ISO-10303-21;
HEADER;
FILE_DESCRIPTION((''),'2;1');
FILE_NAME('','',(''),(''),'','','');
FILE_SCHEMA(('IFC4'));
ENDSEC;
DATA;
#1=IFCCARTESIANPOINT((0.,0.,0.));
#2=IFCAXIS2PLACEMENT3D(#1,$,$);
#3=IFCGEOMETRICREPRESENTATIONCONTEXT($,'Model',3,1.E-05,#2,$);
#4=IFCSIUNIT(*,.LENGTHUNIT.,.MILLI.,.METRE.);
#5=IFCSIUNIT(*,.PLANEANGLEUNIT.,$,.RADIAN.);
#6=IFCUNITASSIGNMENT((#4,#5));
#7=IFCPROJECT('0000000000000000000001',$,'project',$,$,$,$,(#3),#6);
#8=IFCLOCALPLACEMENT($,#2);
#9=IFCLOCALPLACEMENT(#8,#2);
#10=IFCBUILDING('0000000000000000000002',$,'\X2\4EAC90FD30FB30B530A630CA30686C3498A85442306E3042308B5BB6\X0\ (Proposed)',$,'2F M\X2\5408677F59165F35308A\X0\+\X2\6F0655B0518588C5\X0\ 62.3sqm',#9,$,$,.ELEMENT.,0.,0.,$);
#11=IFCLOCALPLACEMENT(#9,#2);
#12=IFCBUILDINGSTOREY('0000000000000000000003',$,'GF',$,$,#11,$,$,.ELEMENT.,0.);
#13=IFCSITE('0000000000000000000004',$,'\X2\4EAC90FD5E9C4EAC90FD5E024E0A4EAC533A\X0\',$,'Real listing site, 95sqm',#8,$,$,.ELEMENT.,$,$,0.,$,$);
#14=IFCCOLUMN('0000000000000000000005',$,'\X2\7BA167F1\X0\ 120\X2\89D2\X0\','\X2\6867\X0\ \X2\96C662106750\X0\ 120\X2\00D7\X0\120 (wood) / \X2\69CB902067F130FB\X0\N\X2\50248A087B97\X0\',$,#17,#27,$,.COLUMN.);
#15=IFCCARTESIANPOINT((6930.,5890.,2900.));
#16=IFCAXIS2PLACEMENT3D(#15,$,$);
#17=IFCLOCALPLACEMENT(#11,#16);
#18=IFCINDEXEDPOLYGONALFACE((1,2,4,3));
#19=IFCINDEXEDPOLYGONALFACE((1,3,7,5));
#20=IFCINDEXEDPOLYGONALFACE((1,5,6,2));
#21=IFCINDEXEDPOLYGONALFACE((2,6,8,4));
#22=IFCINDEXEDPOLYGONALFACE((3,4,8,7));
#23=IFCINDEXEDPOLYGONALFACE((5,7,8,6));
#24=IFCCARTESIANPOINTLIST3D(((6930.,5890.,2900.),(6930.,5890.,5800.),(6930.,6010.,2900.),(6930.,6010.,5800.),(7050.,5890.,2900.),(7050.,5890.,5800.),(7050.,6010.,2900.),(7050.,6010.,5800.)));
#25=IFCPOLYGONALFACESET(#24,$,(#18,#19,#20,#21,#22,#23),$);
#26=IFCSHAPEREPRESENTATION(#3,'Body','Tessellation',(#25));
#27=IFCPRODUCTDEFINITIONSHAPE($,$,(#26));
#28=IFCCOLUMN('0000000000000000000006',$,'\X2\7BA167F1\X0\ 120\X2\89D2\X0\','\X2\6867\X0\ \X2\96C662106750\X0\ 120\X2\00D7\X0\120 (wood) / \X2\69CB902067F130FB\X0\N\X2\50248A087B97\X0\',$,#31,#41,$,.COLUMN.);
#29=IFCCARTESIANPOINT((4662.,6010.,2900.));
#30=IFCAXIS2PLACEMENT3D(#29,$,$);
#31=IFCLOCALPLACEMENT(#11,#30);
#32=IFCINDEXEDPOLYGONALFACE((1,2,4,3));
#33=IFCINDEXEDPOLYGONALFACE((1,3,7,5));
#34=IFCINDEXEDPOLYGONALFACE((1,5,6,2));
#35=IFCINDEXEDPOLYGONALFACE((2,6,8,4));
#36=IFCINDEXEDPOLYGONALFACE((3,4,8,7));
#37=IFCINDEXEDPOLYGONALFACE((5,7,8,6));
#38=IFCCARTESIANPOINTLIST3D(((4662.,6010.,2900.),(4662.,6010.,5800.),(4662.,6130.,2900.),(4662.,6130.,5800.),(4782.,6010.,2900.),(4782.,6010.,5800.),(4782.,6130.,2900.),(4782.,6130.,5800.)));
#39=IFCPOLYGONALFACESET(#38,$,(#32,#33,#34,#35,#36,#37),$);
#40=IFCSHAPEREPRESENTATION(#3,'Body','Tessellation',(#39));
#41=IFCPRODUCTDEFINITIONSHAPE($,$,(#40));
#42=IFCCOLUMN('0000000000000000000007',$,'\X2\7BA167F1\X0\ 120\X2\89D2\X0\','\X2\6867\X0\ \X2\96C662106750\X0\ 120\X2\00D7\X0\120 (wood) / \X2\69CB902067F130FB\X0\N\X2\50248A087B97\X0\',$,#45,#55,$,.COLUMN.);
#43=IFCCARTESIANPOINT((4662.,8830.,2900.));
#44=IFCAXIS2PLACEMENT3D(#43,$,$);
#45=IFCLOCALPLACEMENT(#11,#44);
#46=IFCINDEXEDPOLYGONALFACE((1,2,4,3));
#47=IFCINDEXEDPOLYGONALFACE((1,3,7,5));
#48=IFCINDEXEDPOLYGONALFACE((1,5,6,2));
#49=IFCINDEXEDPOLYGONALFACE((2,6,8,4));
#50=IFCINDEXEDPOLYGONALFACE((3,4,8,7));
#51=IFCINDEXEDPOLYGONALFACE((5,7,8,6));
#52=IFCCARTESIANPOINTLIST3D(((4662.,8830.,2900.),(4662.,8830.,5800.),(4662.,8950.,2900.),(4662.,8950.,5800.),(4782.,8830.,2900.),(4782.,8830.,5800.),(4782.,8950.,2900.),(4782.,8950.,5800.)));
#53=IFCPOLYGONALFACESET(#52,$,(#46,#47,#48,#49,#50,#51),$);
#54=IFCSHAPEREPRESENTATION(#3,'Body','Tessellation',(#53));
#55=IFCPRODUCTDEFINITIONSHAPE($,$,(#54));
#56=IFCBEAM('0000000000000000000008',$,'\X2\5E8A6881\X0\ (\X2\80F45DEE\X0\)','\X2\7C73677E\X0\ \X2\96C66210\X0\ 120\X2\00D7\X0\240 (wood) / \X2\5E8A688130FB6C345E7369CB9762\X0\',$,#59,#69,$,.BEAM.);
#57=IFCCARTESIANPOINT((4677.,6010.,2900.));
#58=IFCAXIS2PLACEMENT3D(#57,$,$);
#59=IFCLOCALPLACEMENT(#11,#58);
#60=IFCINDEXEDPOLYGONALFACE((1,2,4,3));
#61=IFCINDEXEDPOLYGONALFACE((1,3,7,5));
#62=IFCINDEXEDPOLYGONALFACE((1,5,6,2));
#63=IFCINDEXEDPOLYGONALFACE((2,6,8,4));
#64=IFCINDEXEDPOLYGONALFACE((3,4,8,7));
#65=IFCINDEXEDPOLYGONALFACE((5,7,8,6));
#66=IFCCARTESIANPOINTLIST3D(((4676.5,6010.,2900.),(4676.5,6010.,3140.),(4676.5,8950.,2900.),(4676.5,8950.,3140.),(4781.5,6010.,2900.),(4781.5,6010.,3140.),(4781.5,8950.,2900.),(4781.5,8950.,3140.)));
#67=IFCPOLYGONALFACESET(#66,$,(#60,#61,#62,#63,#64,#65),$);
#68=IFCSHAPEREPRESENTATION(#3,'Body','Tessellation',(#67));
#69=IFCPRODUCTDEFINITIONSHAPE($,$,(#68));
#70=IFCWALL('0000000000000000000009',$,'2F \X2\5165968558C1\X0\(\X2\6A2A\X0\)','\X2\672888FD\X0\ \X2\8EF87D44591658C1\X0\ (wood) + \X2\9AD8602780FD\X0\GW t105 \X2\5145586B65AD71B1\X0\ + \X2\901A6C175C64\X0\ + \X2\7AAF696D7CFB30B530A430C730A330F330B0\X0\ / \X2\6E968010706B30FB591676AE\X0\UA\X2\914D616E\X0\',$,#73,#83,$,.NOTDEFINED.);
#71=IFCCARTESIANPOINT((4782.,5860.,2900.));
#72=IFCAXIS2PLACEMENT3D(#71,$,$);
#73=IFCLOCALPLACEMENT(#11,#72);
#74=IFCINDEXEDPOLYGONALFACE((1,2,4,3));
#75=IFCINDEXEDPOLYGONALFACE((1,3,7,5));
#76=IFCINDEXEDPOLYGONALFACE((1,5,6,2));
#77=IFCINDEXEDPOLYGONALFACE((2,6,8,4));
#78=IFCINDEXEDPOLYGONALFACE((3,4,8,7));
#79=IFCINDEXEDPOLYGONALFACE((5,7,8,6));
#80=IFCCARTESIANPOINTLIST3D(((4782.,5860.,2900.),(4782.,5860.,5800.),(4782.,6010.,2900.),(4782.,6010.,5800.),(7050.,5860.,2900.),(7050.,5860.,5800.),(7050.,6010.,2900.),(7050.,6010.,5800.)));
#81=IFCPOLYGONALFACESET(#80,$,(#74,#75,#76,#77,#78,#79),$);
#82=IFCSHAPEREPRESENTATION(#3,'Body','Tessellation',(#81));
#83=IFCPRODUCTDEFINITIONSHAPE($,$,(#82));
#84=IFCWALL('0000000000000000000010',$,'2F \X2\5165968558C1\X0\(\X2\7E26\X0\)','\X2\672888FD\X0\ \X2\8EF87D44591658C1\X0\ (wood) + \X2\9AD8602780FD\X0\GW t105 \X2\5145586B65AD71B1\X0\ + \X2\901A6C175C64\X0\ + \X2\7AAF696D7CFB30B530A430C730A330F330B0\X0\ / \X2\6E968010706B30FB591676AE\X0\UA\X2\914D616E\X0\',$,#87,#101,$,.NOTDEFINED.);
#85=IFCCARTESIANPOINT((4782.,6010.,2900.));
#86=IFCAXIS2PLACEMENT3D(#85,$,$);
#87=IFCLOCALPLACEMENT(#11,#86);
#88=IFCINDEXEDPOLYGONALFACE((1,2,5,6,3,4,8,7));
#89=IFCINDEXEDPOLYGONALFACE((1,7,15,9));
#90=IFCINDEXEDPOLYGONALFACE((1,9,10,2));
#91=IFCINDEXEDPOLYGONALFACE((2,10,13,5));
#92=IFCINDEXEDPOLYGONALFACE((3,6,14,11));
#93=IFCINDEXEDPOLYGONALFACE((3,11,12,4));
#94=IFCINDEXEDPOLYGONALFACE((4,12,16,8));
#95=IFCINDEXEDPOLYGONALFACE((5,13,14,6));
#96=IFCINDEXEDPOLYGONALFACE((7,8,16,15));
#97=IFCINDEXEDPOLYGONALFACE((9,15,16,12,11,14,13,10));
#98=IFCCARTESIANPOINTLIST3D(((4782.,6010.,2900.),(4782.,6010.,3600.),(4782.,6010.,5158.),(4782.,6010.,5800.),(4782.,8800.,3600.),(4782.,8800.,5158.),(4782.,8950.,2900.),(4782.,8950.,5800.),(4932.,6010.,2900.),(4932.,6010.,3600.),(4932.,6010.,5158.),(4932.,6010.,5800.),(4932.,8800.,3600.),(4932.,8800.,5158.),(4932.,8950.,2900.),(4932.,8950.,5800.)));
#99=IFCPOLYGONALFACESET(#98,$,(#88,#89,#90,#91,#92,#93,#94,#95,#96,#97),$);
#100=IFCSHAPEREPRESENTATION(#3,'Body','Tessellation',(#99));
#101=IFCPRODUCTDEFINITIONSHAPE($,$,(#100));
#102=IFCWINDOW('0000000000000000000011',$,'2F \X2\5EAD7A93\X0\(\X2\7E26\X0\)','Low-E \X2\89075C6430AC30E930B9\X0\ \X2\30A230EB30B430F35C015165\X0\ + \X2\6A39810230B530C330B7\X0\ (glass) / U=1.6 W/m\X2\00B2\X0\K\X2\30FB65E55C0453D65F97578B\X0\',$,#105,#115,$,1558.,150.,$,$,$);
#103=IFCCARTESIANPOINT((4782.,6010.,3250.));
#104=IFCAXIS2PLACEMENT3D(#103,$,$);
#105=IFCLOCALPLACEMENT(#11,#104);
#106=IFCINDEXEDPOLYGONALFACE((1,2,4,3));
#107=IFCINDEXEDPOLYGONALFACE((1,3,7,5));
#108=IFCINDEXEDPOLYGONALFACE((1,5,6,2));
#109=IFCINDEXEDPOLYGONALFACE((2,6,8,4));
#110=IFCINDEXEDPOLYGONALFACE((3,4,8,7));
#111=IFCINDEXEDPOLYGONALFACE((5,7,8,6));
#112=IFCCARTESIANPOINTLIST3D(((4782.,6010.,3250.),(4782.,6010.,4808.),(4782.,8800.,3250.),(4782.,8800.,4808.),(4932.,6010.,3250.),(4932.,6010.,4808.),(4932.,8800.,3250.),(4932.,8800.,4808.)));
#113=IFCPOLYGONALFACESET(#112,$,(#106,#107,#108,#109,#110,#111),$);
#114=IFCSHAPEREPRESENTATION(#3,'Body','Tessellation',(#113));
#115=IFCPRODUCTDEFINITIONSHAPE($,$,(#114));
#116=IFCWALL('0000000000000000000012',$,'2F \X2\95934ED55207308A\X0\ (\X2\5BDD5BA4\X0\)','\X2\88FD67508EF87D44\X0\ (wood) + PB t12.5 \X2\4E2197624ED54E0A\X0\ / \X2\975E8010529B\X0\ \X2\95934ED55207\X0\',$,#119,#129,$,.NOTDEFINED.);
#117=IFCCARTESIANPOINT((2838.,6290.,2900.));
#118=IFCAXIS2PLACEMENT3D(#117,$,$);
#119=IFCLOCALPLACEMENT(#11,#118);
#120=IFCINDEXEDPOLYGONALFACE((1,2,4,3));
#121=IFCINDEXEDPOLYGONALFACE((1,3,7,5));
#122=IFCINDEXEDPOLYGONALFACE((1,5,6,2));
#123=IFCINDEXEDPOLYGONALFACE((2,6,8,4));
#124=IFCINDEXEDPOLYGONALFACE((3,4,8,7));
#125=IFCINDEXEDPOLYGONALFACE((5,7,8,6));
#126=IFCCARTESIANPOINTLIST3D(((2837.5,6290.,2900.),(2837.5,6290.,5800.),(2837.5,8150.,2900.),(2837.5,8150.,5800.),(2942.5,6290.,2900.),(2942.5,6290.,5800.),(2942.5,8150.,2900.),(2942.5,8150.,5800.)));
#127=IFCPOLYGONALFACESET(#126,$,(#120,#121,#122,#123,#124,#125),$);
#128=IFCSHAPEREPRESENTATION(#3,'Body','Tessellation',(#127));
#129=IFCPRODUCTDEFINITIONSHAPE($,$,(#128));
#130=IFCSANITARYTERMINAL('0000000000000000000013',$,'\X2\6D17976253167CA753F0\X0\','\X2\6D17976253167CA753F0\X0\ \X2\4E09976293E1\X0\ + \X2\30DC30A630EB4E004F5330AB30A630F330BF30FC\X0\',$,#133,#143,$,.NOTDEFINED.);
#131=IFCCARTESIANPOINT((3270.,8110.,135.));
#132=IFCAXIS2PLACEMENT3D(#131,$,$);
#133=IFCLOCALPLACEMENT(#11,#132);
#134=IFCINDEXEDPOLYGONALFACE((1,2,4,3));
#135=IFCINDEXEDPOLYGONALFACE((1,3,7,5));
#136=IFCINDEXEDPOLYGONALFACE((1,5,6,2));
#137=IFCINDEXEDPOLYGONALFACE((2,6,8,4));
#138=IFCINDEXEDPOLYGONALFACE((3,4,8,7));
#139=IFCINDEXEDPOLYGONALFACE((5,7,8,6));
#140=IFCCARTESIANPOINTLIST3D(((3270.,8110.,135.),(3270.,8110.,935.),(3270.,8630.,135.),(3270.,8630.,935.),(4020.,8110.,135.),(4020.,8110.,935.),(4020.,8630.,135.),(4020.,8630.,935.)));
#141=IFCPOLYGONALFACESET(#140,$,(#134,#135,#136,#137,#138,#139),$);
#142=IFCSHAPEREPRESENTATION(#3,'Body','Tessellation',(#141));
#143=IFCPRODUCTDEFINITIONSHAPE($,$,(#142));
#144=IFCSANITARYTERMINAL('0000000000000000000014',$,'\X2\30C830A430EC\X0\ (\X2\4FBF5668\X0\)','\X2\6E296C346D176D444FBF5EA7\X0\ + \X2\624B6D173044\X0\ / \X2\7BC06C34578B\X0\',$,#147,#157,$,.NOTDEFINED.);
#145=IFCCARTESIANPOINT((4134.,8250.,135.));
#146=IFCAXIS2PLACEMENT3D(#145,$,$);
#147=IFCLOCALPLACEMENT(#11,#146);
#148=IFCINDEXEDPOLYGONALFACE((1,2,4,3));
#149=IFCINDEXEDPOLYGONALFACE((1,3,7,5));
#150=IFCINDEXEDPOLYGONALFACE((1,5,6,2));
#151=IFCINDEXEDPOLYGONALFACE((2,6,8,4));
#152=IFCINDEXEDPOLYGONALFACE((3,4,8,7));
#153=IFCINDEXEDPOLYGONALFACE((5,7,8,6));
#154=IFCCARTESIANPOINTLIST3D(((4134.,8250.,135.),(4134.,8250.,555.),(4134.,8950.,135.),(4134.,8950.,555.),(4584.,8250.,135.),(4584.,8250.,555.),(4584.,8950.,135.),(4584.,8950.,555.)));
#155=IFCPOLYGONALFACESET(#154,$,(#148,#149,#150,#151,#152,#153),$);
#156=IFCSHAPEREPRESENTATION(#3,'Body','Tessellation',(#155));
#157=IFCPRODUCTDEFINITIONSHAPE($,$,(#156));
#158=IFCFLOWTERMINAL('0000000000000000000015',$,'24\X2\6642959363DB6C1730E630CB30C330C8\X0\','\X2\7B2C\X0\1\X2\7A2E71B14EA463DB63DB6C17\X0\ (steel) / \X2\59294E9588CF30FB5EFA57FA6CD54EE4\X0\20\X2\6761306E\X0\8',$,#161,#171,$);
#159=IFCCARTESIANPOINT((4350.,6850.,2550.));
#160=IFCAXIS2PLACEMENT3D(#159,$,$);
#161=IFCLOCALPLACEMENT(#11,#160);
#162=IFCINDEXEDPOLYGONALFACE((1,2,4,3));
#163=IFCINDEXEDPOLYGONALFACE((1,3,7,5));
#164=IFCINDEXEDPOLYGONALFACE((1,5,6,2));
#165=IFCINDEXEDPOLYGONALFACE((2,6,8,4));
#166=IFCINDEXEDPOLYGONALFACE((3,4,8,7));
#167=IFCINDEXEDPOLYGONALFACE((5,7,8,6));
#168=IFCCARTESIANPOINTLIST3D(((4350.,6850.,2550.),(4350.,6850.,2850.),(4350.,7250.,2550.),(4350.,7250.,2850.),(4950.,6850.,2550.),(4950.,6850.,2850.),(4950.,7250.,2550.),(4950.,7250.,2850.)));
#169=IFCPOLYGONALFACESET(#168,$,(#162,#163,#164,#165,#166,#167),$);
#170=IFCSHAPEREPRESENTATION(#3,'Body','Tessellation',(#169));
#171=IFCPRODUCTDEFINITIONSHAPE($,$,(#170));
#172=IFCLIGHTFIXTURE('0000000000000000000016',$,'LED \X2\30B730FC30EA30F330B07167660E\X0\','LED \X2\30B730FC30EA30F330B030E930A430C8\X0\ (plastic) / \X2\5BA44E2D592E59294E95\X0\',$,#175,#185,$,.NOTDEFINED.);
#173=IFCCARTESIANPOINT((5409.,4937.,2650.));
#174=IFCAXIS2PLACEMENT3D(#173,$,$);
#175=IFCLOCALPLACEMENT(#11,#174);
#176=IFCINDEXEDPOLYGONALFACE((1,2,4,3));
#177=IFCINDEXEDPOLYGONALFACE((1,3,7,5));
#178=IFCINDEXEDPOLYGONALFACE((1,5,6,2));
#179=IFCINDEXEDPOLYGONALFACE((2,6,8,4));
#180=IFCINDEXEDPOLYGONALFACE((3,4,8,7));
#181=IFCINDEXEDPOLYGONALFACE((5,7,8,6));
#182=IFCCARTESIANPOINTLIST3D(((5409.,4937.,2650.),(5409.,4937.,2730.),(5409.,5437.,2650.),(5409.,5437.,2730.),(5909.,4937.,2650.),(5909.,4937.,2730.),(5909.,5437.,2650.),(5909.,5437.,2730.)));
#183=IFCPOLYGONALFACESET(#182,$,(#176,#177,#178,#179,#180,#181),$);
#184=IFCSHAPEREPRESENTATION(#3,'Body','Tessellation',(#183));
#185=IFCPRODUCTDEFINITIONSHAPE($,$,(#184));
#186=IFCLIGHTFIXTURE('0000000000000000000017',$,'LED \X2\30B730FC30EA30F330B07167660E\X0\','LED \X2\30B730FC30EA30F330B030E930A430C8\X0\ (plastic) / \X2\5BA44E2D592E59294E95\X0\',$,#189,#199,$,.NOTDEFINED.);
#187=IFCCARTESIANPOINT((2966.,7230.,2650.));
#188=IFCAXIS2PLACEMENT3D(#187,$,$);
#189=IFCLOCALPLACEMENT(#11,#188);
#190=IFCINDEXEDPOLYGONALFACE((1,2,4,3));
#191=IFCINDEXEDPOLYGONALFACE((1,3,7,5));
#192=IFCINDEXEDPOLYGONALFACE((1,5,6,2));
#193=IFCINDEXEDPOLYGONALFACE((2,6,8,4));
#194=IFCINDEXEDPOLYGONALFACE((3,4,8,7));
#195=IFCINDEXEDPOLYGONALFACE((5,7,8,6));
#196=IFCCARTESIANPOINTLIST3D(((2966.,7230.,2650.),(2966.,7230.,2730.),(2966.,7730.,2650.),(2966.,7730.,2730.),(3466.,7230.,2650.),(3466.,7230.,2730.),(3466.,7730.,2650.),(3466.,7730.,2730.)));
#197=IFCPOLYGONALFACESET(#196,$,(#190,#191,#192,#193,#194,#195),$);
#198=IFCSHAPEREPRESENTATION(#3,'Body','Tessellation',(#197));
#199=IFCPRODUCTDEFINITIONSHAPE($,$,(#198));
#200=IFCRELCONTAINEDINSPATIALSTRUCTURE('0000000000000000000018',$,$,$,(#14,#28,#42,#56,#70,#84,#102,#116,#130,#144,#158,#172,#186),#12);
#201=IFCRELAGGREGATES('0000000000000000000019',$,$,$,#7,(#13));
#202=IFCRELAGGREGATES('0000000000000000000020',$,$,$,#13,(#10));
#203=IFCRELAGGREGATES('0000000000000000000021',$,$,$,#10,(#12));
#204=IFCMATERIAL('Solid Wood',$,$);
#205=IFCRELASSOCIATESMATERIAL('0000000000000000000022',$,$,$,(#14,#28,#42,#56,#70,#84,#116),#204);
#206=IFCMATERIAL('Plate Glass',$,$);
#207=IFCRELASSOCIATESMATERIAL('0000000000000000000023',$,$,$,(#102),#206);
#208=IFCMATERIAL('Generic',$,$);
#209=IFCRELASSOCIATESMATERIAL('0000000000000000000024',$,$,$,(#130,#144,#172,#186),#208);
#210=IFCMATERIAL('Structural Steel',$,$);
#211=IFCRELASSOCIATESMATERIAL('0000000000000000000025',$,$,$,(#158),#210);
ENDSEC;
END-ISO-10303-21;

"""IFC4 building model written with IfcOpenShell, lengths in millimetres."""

from ifc_helpers import new_model, si_unit, frame, frame_2d, origin, place, context, project, spatial, rectangle, extrude, material, element, fill, save


model = new_model("IFC4")

# Units and contexts
model_context = context("Model", 3, precision=1e-05, world=origin())
ifc_project = project(units=[si_unit("LENGTHUNIT", "METRE", prefix="MILLI"), si_unit("PLANEANGLEUNIT", "RADIAN")], contexts=[model_context])

# Site, building, storey
site_placement = place(None, origin())
site = spatial("IfcSite", under=ifc_project, at=site_placement, Name="京都府京都市上京区", ObjectType="Real listing site, 95sqm", CompositionType="ELEMENT", RefElevation=0.0)
building_placement = place(site_placement, origin())
building = spatial("IfcBuilding", under=site, at=building_placement, Name="京都・サウナと水風呂のある家 (Proposed)", ObjectType="2F M合板外張り+漆喰内装 62.3sqm", CompositionType="ELEMENT", ElevationOfRefHeight=0.0, ElevationOfTerrain=0.0)
storey_placement = place(building_placement, origin())
storey = spatial("IfcBuildingStorey", under=building, at=storey_placement, Name="GF", CompositionType="ELEMENT", Elevation=0.0)

# Columns
ifc_material_1 = material(Name="Solid Wood")
column_1_placement = place(storey_placement, frame((6930.0, 5890.0, 2900.0)))
element("IfcColumn", 1, at=column_1_placement, inside=storey, material=ifc_material_1, Name="管柱 120角", Description="桧 集成材 120×120 (wood) / 構造柱・N値計算", PredefinedType="COLUMN", context=model_context, shape_type="SweptSolid", body=[
    extrude(rectangle(XDim=120.0, YDim=120.0, at=frame_2d((60.0, 60.0))), frame((6930.0, 5890.0, 2900.0)), (0.0, 0.0, 1.0), 2900.0),
])
column_2_placement = place(storey_placement, frame((4662.0, 6010.0, 2900.0)))
element("IfcColumn", 2, at=column_2_placement, inside=storey, material=ifc_material_1, Name="管柱 120角", Description="桧 集成材 120×120 (wood) / 構造柱・N値計算", PredefinedType="COLUMN", context=model_context, shape_type="SweptSolid", body=[
    extrude(rectangle(XDim=120.0, YDim=120.0, at=frame_2d((60.0, 60.0))), frame((4662.0, 6010.0, 2900.0)), (0.0, 0.0, 1.0), 2900.0),
])
column_3_placement = place(storey_placement, frame((4662.0, 8830.0, 2900.0)))
element("IfcColumn", 3, at=column_3_placement, inside=storey, material=ifc_material_1, Name="管柱 120角", Description="桧 集成材 120×120 (wood) / 構造柱・N値計算", PredefinedType="COLUMN", context=model_context, shape_type="SweptSolid", body=[
    extrude(rectangle(XDim=120.0, YDim=120.0, at=frame_2d((60.0, 60.0))), frame((4662.0, 8830.0, 2900.0)), (0.0, 0.0, 1.0), 2900.0),
])

# Beam
beam_placement = place(storey_placement, frame((4677.0, 6010.0, 2900.0)))
element("IfcBeam", 4, at=beam_placement, inside=storey, material=ifc_material_1, Name="床梁 (胴差)", Description="米松 集成 120×240 (wood) / 床梁・水平構面", PredefinedType="BEAM", context=model_context, shape_type="SweptSolid", body=[
    extrude(rectangle(XDim=105.0, YDim=2940.0, at=frame_2d((52.0, 1470.0))), frame((4677.0, 6010.0, 2900.0)), (0.0, 0.0, 1.0), 240.0),
])

# Wall
wall_1_placement = place(storey_placement, frame((4782.0, 5860.0, 2900.0)))
element("IfcWall", 5, at=wall_1_placement, inside=storey, material=ifc_material_1, Name="2F 入隅壁(横)", Description="木製 軸組外壁 (wood) + 高性能GW t105 充填断熱 + 通気層 + 窯業系サイディング / 準耐火・外皮UA配慮", PredefinedType="NOTDEFINED", context=model_context, shape_type="SweptSolid", body=[
    extrude(rectangle(XDim=2268.0, YDim=150.0, at=frame_2d((1134.0, 75.0))), frame((4782.0, 5860.0, 2900.0)), (0.0, 0.0, 1.0), 2900.0),
])

# Wall, opening, window
wall_2_placement = place(storey_placement, frame((4782.0, 6010.0, 2900.0)))
wall_2 = element("IfcWall", 6, at=wall_2_placement, inside=storey, material=ifc_material_1, Name="2F 入隅壁(縦)", Description="木製 軸組外壁 (wood) + 高性能GW t105 充填断熱 + 通気層 + 窯業系サイディング / 準耐火・外皮UA配慮", PredefinedType="NOTDEFINED", context=model_context, shape_type="SweptSolid", body=[
    extrude(rectangle(XDim=150.0, YDim=2940.0, at=frame_2d((75.0, 1470.0))), frame((4782.0, 6010.0, 2900.0)), (0.0, 0.0, 1.0), 2900.0),
])
opening_placement = place(storey_placement, frame((4782.0, 6010.0, 3250.0)))
opening = element("IfcOpeningElement", 7, at=opening_placement, cuts=wall_2, PredefinedType="NOTDEFINED", context=model_context, shape_type="SweptSolid", body=[
    extrude(rectangle(XDim=150.0, YDim=2790.0, at=frame_2d((75.0, 1395.0))), frame((4782.0, 6010.0, 3250.0)), (0.0, 0.0, 1.0), 1558.0),
])
ifc_material_2 = material(Name="Plate Glass")
window_placement = place(storey_placement, frame((4782.0, 6010.0, 3250.0)))
window = element("IfcWindow", 8, at=window_placement, inside=storey, material=ifc_material_2, Name="2F 庭窓(縦)", Description="Low-E 複層ガラス アルゴン封入 + 樹脂サッシ (glass) / U=1.6 W/m²K・日射取得型", OverallHeight=1558.0, OverallWidth=150.0, context=model_context, shape_type="SweptSolid", body=[
    extrude(rectangle(XDim=150.0, YDim=2790.0, at=frame_2d((75.0, 1395.0))), frame((4782.0, 6010.0, 3250.0)), (0.0, 0.0, 1.0), 1558.0),
])
fill(opening, window)

# Wall
wall_3_placement = place(storey_placement, frame((2838.0, 6290.0, 2900.0)))
element("IfcWall", 9, at=wall_3_placement, inside=storey, material=ifc_material_1, Name="2F 間仕切り (寝室)", Description="製材軸組 (wood) + PB t12.5 両面仕上 / 非耐力 間仕切", PredefinedType="NOTDEFINED", context=model_context, shape_type="SweptSolid", body=[
    extrude(rectangle(XDim=105.0, YDim=1860.0, at=frame_2d((52.0, 930.0))), frame((2838.0, 6290.0, 2900.0)), (0.0, 0.0, 1.0), 2900.0),
])

# Sanitary terminals
ifc_material_3 = material(Name="Generic")
sanitary_terminal_1_placement = place(storey_placement, frame((3270.0, 8110.0, 135.0)))
element("IfcSanitaryTerminal", 10, at=sanitary_terminal_1_placement, inside=storey, material=ifc_material_3, Name="洗面化粧台", Description="洗面化粧台 三面鏡 + ボウル一体カウンター", PredefinedType="NOTDEFINED", context=model_context, shape_type="SweptSolid", body=[
    extrude(rectangle(XDim=750.0, YDim=520.0, at=frame_2d((375.0, 260.0))), frame((3270.0, 8110.0, 135.0)), (0.0, 0.0, 1.0), 800.0),
])
sanitary_terminal_2_placement = place(storey_placement, frame((4134.0, 8250.0, 135.0)))
element("IfcSanitaryTerminal", 11, at=sanitary_terminal_2_placement, inside=storey, material=ifc_material_3, Name="トイレ (便器)", Description="温水洗浄便座 + 手洗い / 節水型", PredefinedType="NOTDEFINED", context=model_context, shape_type="SweptSolid", body=[
    extrude(rectangle(XDim=450.0, YDim=700.0, at=frame_2d((225.0, 350.0))), frame((4134.0, 8250.0, 135.0)), (0.0, 0.0, 1.0), 420.0),
])

# Flow terminal
ifc_material_4 = material(Name="Structural Steel")
flow_terminal_placement = place(storey_placement, frame((4350.0, 6850.0, 2550.0)))
element("IfcFlowTerminal", 12, at=flow_terminal_placement, inside=storey, material=ifc_material_4, Name="24時間換気ユニット", Description="第1種熱交換換気 (steel) / 天井裏・建基法令20条の8", context=model_context, shape_type="SweptSolid", body=[
    extrude(rectangle(XDim=600.0, YDim=400.0, at=frame_2d((300.0, 200.0))), frame((4350.0, 6850.0, 2550.0)), (0.0, 0.0, 1.0), 300.0),
])

# Light fixtures
light_fixture_1_placement = place(storey_placement, frame((5409.0, 4937.0, 2650.0)))
element("IfcLightFixture", 13, at=light_fixture_1_placement, inside=storey, material=ifc_material_3, Name="LED シーリング照明", Description="LED シーリングライト (plastic) / 室中央天井", PredefinedType="NOTDEFINED", context=model_context, shape_type="SweptSolid", body=[
    extrude(rectangle(XDim=500.0, YDim=500.0, at=frame_2d((250.0, 250.0))), frame((5409.0, 4937.0, 2650.0)), (0.0, 0.0, 1.0), 80.0),
])
light_fixture_2_placement = place(storey_placement, frame((2966.0, 7230.0, 2650.0)))
element("IfcLightFixture", 14, at=light_fixture_2_placement, inside=storey, material=ifc_material_3, Name="LED シーリング照明", Description="LED シーリングライト (plastic) / 室中央天井", PredefinedType="NOTDEFINED", context=model_context, shape_type="SweptSolid", body=[
    extrude(rectangle(XDim=500.0, YDim=500.0, at=frame_2d((250.0, 250.0))), frame((2966.0, 7230.0, 2650.0)), (0.0, 0.0, 1.0), 80.0),
])

save(model, "model.ifc")
